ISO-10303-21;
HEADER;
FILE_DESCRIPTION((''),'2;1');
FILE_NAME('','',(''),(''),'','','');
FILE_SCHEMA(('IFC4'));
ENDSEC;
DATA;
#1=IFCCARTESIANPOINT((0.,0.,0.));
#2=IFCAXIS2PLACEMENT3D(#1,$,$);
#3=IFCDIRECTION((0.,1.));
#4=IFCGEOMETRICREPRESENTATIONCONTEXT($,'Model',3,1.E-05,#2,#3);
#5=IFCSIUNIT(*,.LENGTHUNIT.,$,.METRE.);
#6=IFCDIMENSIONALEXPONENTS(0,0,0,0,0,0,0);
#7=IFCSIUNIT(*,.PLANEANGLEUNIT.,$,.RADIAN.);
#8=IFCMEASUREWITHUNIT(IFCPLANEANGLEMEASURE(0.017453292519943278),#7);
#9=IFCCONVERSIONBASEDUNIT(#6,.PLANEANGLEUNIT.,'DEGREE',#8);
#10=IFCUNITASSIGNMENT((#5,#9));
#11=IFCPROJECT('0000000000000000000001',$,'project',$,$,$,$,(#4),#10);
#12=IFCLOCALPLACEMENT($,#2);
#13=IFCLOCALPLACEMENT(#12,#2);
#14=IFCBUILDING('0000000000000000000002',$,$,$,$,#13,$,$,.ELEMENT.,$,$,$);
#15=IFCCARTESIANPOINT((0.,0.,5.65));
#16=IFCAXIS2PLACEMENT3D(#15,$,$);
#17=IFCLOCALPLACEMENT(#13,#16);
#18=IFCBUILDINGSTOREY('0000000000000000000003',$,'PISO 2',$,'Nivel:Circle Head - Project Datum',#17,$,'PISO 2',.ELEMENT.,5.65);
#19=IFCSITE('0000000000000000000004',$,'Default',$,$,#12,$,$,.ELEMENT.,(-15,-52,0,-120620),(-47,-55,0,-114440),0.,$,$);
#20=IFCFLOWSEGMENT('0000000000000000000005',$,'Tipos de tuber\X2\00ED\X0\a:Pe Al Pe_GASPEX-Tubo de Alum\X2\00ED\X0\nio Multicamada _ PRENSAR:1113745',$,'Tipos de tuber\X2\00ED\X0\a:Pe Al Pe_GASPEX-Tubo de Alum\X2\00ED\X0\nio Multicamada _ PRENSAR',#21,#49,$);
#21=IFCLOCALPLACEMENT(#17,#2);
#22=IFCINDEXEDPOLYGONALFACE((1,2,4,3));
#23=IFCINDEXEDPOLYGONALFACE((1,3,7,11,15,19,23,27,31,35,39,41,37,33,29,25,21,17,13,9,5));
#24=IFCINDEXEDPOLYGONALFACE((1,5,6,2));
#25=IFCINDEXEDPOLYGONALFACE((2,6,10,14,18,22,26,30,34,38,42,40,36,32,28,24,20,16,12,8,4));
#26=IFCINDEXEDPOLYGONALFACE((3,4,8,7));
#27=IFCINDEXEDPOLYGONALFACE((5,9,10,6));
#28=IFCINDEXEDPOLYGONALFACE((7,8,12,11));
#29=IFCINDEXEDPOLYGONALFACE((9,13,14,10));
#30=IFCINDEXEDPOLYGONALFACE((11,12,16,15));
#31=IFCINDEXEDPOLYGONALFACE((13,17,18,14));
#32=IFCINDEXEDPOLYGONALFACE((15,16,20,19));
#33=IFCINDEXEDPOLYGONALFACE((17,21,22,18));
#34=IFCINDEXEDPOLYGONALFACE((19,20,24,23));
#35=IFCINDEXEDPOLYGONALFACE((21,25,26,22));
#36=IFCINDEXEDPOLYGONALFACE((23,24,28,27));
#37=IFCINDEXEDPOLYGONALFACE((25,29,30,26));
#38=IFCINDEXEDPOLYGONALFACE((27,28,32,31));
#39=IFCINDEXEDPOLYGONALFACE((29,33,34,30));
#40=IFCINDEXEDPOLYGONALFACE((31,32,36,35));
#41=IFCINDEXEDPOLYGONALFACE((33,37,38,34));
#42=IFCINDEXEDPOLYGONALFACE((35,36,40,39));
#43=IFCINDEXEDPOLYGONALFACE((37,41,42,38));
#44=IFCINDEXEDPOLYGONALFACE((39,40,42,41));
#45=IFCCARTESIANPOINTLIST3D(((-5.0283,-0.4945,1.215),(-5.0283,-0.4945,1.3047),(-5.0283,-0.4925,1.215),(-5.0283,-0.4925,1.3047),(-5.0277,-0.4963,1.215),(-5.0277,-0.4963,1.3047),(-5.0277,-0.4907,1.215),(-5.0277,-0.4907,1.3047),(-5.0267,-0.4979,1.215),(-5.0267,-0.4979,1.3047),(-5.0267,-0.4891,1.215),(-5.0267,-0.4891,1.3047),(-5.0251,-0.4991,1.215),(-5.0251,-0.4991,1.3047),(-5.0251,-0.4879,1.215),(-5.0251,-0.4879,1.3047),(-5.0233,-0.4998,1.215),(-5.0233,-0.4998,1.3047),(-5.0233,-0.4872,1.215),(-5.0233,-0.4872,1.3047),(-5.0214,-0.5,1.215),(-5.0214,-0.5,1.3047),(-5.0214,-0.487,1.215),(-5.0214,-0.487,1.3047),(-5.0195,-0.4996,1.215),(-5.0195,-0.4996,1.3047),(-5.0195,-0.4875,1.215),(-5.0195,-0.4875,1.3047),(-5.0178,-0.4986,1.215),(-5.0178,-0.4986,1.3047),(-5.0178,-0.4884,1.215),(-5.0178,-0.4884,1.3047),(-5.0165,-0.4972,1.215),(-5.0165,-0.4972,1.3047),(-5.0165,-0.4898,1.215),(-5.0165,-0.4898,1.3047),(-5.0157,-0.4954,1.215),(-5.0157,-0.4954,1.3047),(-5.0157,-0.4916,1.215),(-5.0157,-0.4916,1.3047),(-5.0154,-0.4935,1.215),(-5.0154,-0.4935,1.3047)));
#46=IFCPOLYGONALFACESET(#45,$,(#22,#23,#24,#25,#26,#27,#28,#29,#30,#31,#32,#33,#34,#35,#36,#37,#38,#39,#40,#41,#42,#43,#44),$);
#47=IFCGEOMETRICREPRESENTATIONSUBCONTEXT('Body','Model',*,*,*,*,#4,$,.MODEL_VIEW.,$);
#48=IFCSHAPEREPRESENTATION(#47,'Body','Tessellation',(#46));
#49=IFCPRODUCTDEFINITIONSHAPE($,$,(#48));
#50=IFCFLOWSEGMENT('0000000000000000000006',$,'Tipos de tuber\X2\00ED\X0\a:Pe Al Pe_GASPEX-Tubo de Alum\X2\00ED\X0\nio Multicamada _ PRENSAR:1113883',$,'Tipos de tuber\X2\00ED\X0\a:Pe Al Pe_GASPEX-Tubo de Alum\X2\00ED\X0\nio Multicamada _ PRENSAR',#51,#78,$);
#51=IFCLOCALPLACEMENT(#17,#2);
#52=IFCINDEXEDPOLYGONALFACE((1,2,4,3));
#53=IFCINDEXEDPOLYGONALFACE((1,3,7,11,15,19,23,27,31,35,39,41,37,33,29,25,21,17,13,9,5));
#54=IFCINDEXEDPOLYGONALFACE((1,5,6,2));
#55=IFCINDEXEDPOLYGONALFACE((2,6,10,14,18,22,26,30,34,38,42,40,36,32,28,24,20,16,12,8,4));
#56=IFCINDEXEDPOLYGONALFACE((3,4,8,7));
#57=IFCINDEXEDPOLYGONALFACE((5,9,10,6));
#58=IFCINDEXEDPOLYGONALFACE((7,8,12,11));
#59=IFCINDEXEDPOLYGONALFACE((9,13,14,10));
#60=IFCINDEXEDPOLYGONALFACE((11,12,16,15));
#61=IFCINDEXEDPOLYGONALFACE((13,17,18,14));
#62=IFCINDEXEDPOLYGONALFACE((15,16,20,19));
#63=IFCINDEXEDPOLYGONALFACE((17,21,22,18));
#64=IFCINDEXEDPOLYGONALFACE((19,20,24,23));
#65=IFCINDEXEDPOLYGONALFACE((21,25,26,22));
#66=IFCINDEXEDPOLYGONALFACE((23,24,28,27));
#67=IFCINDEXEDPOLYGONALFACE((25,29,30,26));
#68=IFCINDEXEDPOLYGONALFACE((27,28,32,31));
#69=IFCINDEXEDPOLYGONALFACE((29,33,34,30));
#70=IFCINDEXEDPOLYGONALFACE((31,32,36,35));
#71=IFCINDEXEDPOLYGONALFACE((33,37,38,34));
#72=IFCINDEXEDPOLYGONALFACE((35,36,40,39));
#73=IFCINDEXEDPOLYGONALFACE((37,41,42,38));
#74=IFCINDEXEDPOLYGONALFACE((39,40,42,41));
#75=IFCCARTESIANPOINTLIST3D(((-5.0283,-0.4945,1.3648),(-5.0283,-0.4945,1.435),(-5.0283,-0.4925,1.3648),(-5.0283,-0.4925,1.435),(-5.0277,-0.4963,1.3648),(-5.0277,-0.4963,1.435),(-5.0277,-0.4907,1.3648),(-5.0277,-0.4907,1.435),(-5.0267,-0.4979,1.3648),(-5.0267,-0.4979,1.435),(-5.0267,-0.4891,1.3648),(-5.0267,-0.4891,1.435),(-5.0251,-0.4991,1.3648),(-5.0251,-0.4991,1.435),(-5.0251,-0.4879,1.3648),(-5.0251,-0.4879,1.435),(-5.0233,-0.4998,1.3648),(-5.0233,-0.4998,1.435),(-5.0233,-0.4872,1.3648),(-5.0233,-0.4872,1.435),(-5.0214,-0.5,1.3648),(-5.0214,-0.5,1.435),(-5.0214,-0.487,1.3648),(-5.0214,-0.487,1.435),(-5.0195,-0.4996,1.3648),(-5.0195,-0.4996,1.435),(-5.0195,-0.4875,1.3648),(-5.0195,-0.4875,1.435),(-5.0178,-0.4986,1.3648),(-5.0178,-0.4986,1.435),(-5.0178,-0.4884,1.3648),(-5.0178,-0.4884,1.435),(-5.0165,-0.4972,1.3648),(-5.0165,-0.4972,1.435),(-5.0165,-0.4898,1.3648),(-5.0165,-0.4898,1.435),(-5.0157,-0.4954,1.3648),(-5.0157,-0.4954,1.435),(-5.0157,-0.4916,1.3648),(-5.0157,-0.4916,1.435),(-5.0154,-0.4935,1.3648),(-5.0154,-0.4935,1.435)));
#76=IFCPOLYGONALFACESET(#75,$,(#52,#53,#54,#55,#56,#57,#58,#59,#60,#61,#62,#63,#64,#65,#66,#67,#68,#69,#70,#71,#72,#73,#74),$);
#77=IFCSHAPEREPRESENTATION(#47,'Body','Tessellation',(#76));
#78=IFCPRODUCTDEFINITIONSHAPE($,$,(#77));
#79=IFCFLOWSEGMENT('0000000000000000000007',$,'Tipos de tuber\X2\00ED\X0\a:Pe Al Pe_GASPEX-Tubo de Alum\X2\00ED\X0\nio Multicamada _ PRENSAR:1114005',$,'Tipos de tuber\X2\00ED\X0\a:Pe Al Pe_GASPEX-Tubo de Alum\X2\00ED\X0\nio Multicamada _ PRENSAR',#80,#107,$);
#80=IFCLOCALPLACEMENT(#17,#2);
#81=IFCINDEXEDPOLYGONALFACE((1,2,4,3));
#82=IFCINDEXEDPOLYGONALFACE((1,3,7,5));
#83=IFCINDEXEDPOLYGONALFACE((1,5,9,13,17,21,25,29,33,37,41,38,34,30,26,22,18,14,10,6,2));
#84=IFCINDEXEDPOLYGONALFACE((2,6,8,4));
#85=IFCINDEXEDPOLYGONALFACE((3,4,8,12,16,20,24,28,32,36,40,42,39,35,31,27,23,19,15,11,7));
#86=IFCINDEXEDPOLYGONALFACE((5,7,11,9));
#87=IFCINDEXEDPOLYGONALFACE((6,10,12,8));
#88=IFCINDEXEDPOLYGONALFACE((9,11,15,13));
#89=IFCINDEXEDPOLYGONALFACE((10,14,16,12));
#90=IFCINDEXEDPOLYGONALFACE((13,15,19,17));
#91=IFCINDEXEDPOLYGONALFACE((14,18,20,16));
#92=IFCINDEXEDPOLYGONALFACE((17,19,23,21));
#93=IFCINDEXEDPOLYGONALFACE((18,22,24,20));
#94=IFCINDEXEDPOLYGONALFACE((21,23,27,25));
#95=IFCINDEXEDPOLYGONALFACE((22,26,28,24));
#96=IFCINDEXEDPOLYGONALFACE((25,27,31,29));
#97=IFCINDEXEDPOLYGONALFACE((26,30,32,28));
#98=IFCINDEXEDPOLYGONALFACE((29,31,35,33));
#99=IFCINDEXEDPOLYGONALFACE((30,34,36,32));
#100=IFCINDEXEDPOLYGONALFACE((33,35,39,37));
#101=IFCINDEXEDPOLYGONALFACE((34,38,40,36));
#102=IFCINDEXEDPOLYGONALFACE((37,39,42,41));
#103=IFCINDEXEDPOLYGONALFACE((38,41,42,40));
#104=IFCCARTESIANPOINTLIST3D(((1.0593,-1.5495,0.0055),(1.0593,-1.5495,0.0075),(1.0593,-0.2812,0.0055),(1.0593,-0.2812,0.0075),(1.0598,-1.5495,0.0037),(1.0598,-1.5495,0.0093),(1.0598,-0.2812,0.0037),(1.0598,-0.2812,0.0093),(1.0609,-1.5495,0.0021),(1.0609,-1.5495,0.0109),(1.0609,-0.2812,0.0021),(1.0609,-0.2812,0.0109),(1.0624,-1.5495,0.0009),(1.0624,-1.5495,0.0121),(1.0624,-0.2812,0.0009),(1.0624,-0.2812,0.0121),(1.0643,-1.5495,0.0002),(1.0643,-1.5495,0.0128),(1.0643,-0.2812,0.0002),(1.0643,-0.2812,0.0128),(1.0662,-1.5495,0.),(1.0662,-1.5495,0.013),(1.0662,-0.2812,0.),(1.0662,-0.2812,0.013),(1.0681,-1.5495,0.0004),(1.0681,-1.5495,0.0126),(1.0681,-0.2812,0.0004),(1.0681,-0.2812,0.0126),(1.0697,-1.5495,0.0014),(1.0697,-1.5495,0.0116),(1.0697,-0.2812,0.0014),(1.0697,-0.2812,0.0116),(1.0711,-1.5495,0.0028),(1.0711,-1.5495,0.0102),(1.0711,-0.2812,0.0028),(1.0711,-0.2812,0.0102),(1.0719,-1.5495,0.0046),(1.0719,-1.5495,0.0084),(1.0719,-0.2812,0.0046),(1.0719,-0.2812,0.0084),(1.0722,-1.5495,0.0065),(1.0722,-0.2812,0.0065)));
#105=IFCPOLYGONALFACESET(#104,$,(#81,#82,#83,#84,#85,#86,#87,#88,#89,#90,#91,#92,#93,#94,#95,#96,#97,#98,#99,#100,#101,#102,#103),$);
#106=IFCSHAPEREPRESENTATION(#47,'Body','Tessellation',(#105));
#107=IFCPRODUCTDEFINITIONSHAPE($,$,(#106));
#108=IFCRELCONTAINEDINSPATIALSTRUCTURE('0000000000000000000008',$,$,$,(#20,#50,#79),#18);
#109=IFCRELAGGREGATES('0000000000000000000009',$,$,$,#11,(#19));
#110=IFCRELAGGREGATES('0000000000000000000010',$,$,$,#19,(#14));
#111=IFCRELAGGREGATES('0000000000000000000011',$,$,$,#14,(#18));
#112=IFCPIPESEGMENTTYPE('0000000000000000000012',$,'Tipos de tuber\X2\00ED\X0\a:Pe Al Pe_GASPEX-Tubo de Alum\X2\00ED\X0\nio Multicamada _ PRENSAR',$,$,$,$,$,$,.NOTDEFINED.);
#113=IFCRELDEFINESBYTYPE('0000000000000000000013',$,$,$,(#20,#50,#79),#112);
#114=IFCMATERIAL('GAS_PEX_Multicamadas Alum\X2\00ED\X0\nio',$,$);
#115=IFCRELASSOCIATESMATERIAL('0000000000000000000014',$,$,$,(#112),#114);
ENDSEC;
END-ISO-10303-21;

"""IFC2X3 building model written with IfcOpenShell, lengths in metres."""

from ifc_helpers import new_model, entity, si_unit, converted_unit, direction, frame, frame_2d, origin, origin_2d_with_axis, place, context, subcontext, project, spatial, circle, extrude, material, type_object, element, save


model = new_model("IFC2X3")

# Units and contexts
model_context = context("Model", 3, precision=1e-05, world=origin(), true_north=direction((0.0, 1.0)))
body_context = subcontext(model_context, "Body", "Model", "MODEL_VIEW")
ifc_project = project(units=[si_unit("LENGTHUNIT", "METRE"), converted_unit("PLANEANGLEUNIT", "DEGREE", entity("IfcPlaneAngleMeasure", 0.017453292519943278), si_unit("PLANEANGLEUNIT", "RADIAN"), dimensions=[0, 0, 0, 0, 0, 0, 0])], contexts=[model_context])

# Site, building, storey
site_placement = place(None, origin())
site = spatial("IfcSite", under=ifc_project, at=site_placement, Name="Default", CompositionType="ELEMENT", RefLatitude=(-15, -52, 0, -120620), RefLongitude=(-47, -55, 0, -114440), RefElevation=0.0)
building_placement = place(site_placement, origin())
building = spatial("IfcBuilding", under=site, at=building_placement, CompositionType="ELEMENT")
storey_placement = place(building_placement, frame((0.0, 0.0, 5.65)))
storey = spatial("IfcBuildingStorey", under=building, at=storey_placement, Name="PISO 2", ObjectType="Nivel:Circle Head - Project Datum", LongName="PISO 2", CompositionType="ELEMENT", Elevation=5.65)

# Flow segments
ifc_material = material(Name="GAS_PEX_Multicamadas Alumínio")
pipe_segment_type = type_object("IfcPipeSegmentType", Name="Tipos de tubería:Pe Al Pe_GASPEX-Tubo de Alumínio Multicamada _ PRENSAR", PredefinedType="NOTDEFINED", material=ifc_material)
flow_segment_1_placement = place(storey_placement, origin())
element("IfcFlowSegment", 1, at=flow_segment_1_placement, inside=storey, type_object=pipe_segment_type, Name="Tipos de tubería:Pe Al Pe_GASPEX-Tubo de Alumínio Multicamada _ PRENSAR:1113745", ObjectType="Tipos de tubería:Pe Al Pe_GASPEX-Tubo de Alumínio Multicamada _ PRENSAR", context=body_context, shape_type="SweptSolid", body=[
    extrude(circle(Radius=0.0065, at=origin_2d_with_axis()), frame((-5.0219, -0.4935, 1.215)), (0.0, 0.0, 1.0), 0.0897),
])
flow_segment_2_placement = place(storey_placement, origin())
element("IfcFlowSegment", 2, at=flow_segment_2_placement, inside=storey, type_object=pipe_segment_type, Name="Tipos de tubería:Pe Al Pe_GASPEX-Tubo de Alumínio Multicamada _ PRENSAR:1113883", ObjectType="Tipos de tubería:Pe Al Pe_GASPEX-Tubo de Alumínio Multicamada _ PRENSAR", context=body_context, shape_type="SweptSolid", body=[
    extrude(circle(Radius=0.0065, at=origin_2d_with_axis()), frame((-5.0219, -0.4935, 1.3648)), (0.0, 0.0, 1.0), 0.0702),
])
flow_segment_3_placement = place(storey_placement, origin())
element("IfcFlowSegment", 3, at=flow_segment_3_placement, inside=storey, type_object=pipe_segment_type, Name="Tipos de tubería:Pe Al Pe_GASPEX-Tubo de Alumínio Multicamada _ PRENSAR:1114005", ObjectType="Tipos de tubería:Pe Al Pe_GASPEX-Tubo de Alumínio Multicamada _ PRENSAR", context=body_context, shape_type="SweptSolid", body=[
    extrude(circle(Radius=0.0065, at=frame_2d((0.0, 0.0), x_axis=(1.0, 0.0))), frame((1.0657, -1.5495, 0.0065), z_axis=(0.0, 1.0, 0.0), x_axis=(1.0, 0.0, 0.0)), (0.0, 0.0, 1.0), 1.2683),
])

save(model, "model.ifc")
